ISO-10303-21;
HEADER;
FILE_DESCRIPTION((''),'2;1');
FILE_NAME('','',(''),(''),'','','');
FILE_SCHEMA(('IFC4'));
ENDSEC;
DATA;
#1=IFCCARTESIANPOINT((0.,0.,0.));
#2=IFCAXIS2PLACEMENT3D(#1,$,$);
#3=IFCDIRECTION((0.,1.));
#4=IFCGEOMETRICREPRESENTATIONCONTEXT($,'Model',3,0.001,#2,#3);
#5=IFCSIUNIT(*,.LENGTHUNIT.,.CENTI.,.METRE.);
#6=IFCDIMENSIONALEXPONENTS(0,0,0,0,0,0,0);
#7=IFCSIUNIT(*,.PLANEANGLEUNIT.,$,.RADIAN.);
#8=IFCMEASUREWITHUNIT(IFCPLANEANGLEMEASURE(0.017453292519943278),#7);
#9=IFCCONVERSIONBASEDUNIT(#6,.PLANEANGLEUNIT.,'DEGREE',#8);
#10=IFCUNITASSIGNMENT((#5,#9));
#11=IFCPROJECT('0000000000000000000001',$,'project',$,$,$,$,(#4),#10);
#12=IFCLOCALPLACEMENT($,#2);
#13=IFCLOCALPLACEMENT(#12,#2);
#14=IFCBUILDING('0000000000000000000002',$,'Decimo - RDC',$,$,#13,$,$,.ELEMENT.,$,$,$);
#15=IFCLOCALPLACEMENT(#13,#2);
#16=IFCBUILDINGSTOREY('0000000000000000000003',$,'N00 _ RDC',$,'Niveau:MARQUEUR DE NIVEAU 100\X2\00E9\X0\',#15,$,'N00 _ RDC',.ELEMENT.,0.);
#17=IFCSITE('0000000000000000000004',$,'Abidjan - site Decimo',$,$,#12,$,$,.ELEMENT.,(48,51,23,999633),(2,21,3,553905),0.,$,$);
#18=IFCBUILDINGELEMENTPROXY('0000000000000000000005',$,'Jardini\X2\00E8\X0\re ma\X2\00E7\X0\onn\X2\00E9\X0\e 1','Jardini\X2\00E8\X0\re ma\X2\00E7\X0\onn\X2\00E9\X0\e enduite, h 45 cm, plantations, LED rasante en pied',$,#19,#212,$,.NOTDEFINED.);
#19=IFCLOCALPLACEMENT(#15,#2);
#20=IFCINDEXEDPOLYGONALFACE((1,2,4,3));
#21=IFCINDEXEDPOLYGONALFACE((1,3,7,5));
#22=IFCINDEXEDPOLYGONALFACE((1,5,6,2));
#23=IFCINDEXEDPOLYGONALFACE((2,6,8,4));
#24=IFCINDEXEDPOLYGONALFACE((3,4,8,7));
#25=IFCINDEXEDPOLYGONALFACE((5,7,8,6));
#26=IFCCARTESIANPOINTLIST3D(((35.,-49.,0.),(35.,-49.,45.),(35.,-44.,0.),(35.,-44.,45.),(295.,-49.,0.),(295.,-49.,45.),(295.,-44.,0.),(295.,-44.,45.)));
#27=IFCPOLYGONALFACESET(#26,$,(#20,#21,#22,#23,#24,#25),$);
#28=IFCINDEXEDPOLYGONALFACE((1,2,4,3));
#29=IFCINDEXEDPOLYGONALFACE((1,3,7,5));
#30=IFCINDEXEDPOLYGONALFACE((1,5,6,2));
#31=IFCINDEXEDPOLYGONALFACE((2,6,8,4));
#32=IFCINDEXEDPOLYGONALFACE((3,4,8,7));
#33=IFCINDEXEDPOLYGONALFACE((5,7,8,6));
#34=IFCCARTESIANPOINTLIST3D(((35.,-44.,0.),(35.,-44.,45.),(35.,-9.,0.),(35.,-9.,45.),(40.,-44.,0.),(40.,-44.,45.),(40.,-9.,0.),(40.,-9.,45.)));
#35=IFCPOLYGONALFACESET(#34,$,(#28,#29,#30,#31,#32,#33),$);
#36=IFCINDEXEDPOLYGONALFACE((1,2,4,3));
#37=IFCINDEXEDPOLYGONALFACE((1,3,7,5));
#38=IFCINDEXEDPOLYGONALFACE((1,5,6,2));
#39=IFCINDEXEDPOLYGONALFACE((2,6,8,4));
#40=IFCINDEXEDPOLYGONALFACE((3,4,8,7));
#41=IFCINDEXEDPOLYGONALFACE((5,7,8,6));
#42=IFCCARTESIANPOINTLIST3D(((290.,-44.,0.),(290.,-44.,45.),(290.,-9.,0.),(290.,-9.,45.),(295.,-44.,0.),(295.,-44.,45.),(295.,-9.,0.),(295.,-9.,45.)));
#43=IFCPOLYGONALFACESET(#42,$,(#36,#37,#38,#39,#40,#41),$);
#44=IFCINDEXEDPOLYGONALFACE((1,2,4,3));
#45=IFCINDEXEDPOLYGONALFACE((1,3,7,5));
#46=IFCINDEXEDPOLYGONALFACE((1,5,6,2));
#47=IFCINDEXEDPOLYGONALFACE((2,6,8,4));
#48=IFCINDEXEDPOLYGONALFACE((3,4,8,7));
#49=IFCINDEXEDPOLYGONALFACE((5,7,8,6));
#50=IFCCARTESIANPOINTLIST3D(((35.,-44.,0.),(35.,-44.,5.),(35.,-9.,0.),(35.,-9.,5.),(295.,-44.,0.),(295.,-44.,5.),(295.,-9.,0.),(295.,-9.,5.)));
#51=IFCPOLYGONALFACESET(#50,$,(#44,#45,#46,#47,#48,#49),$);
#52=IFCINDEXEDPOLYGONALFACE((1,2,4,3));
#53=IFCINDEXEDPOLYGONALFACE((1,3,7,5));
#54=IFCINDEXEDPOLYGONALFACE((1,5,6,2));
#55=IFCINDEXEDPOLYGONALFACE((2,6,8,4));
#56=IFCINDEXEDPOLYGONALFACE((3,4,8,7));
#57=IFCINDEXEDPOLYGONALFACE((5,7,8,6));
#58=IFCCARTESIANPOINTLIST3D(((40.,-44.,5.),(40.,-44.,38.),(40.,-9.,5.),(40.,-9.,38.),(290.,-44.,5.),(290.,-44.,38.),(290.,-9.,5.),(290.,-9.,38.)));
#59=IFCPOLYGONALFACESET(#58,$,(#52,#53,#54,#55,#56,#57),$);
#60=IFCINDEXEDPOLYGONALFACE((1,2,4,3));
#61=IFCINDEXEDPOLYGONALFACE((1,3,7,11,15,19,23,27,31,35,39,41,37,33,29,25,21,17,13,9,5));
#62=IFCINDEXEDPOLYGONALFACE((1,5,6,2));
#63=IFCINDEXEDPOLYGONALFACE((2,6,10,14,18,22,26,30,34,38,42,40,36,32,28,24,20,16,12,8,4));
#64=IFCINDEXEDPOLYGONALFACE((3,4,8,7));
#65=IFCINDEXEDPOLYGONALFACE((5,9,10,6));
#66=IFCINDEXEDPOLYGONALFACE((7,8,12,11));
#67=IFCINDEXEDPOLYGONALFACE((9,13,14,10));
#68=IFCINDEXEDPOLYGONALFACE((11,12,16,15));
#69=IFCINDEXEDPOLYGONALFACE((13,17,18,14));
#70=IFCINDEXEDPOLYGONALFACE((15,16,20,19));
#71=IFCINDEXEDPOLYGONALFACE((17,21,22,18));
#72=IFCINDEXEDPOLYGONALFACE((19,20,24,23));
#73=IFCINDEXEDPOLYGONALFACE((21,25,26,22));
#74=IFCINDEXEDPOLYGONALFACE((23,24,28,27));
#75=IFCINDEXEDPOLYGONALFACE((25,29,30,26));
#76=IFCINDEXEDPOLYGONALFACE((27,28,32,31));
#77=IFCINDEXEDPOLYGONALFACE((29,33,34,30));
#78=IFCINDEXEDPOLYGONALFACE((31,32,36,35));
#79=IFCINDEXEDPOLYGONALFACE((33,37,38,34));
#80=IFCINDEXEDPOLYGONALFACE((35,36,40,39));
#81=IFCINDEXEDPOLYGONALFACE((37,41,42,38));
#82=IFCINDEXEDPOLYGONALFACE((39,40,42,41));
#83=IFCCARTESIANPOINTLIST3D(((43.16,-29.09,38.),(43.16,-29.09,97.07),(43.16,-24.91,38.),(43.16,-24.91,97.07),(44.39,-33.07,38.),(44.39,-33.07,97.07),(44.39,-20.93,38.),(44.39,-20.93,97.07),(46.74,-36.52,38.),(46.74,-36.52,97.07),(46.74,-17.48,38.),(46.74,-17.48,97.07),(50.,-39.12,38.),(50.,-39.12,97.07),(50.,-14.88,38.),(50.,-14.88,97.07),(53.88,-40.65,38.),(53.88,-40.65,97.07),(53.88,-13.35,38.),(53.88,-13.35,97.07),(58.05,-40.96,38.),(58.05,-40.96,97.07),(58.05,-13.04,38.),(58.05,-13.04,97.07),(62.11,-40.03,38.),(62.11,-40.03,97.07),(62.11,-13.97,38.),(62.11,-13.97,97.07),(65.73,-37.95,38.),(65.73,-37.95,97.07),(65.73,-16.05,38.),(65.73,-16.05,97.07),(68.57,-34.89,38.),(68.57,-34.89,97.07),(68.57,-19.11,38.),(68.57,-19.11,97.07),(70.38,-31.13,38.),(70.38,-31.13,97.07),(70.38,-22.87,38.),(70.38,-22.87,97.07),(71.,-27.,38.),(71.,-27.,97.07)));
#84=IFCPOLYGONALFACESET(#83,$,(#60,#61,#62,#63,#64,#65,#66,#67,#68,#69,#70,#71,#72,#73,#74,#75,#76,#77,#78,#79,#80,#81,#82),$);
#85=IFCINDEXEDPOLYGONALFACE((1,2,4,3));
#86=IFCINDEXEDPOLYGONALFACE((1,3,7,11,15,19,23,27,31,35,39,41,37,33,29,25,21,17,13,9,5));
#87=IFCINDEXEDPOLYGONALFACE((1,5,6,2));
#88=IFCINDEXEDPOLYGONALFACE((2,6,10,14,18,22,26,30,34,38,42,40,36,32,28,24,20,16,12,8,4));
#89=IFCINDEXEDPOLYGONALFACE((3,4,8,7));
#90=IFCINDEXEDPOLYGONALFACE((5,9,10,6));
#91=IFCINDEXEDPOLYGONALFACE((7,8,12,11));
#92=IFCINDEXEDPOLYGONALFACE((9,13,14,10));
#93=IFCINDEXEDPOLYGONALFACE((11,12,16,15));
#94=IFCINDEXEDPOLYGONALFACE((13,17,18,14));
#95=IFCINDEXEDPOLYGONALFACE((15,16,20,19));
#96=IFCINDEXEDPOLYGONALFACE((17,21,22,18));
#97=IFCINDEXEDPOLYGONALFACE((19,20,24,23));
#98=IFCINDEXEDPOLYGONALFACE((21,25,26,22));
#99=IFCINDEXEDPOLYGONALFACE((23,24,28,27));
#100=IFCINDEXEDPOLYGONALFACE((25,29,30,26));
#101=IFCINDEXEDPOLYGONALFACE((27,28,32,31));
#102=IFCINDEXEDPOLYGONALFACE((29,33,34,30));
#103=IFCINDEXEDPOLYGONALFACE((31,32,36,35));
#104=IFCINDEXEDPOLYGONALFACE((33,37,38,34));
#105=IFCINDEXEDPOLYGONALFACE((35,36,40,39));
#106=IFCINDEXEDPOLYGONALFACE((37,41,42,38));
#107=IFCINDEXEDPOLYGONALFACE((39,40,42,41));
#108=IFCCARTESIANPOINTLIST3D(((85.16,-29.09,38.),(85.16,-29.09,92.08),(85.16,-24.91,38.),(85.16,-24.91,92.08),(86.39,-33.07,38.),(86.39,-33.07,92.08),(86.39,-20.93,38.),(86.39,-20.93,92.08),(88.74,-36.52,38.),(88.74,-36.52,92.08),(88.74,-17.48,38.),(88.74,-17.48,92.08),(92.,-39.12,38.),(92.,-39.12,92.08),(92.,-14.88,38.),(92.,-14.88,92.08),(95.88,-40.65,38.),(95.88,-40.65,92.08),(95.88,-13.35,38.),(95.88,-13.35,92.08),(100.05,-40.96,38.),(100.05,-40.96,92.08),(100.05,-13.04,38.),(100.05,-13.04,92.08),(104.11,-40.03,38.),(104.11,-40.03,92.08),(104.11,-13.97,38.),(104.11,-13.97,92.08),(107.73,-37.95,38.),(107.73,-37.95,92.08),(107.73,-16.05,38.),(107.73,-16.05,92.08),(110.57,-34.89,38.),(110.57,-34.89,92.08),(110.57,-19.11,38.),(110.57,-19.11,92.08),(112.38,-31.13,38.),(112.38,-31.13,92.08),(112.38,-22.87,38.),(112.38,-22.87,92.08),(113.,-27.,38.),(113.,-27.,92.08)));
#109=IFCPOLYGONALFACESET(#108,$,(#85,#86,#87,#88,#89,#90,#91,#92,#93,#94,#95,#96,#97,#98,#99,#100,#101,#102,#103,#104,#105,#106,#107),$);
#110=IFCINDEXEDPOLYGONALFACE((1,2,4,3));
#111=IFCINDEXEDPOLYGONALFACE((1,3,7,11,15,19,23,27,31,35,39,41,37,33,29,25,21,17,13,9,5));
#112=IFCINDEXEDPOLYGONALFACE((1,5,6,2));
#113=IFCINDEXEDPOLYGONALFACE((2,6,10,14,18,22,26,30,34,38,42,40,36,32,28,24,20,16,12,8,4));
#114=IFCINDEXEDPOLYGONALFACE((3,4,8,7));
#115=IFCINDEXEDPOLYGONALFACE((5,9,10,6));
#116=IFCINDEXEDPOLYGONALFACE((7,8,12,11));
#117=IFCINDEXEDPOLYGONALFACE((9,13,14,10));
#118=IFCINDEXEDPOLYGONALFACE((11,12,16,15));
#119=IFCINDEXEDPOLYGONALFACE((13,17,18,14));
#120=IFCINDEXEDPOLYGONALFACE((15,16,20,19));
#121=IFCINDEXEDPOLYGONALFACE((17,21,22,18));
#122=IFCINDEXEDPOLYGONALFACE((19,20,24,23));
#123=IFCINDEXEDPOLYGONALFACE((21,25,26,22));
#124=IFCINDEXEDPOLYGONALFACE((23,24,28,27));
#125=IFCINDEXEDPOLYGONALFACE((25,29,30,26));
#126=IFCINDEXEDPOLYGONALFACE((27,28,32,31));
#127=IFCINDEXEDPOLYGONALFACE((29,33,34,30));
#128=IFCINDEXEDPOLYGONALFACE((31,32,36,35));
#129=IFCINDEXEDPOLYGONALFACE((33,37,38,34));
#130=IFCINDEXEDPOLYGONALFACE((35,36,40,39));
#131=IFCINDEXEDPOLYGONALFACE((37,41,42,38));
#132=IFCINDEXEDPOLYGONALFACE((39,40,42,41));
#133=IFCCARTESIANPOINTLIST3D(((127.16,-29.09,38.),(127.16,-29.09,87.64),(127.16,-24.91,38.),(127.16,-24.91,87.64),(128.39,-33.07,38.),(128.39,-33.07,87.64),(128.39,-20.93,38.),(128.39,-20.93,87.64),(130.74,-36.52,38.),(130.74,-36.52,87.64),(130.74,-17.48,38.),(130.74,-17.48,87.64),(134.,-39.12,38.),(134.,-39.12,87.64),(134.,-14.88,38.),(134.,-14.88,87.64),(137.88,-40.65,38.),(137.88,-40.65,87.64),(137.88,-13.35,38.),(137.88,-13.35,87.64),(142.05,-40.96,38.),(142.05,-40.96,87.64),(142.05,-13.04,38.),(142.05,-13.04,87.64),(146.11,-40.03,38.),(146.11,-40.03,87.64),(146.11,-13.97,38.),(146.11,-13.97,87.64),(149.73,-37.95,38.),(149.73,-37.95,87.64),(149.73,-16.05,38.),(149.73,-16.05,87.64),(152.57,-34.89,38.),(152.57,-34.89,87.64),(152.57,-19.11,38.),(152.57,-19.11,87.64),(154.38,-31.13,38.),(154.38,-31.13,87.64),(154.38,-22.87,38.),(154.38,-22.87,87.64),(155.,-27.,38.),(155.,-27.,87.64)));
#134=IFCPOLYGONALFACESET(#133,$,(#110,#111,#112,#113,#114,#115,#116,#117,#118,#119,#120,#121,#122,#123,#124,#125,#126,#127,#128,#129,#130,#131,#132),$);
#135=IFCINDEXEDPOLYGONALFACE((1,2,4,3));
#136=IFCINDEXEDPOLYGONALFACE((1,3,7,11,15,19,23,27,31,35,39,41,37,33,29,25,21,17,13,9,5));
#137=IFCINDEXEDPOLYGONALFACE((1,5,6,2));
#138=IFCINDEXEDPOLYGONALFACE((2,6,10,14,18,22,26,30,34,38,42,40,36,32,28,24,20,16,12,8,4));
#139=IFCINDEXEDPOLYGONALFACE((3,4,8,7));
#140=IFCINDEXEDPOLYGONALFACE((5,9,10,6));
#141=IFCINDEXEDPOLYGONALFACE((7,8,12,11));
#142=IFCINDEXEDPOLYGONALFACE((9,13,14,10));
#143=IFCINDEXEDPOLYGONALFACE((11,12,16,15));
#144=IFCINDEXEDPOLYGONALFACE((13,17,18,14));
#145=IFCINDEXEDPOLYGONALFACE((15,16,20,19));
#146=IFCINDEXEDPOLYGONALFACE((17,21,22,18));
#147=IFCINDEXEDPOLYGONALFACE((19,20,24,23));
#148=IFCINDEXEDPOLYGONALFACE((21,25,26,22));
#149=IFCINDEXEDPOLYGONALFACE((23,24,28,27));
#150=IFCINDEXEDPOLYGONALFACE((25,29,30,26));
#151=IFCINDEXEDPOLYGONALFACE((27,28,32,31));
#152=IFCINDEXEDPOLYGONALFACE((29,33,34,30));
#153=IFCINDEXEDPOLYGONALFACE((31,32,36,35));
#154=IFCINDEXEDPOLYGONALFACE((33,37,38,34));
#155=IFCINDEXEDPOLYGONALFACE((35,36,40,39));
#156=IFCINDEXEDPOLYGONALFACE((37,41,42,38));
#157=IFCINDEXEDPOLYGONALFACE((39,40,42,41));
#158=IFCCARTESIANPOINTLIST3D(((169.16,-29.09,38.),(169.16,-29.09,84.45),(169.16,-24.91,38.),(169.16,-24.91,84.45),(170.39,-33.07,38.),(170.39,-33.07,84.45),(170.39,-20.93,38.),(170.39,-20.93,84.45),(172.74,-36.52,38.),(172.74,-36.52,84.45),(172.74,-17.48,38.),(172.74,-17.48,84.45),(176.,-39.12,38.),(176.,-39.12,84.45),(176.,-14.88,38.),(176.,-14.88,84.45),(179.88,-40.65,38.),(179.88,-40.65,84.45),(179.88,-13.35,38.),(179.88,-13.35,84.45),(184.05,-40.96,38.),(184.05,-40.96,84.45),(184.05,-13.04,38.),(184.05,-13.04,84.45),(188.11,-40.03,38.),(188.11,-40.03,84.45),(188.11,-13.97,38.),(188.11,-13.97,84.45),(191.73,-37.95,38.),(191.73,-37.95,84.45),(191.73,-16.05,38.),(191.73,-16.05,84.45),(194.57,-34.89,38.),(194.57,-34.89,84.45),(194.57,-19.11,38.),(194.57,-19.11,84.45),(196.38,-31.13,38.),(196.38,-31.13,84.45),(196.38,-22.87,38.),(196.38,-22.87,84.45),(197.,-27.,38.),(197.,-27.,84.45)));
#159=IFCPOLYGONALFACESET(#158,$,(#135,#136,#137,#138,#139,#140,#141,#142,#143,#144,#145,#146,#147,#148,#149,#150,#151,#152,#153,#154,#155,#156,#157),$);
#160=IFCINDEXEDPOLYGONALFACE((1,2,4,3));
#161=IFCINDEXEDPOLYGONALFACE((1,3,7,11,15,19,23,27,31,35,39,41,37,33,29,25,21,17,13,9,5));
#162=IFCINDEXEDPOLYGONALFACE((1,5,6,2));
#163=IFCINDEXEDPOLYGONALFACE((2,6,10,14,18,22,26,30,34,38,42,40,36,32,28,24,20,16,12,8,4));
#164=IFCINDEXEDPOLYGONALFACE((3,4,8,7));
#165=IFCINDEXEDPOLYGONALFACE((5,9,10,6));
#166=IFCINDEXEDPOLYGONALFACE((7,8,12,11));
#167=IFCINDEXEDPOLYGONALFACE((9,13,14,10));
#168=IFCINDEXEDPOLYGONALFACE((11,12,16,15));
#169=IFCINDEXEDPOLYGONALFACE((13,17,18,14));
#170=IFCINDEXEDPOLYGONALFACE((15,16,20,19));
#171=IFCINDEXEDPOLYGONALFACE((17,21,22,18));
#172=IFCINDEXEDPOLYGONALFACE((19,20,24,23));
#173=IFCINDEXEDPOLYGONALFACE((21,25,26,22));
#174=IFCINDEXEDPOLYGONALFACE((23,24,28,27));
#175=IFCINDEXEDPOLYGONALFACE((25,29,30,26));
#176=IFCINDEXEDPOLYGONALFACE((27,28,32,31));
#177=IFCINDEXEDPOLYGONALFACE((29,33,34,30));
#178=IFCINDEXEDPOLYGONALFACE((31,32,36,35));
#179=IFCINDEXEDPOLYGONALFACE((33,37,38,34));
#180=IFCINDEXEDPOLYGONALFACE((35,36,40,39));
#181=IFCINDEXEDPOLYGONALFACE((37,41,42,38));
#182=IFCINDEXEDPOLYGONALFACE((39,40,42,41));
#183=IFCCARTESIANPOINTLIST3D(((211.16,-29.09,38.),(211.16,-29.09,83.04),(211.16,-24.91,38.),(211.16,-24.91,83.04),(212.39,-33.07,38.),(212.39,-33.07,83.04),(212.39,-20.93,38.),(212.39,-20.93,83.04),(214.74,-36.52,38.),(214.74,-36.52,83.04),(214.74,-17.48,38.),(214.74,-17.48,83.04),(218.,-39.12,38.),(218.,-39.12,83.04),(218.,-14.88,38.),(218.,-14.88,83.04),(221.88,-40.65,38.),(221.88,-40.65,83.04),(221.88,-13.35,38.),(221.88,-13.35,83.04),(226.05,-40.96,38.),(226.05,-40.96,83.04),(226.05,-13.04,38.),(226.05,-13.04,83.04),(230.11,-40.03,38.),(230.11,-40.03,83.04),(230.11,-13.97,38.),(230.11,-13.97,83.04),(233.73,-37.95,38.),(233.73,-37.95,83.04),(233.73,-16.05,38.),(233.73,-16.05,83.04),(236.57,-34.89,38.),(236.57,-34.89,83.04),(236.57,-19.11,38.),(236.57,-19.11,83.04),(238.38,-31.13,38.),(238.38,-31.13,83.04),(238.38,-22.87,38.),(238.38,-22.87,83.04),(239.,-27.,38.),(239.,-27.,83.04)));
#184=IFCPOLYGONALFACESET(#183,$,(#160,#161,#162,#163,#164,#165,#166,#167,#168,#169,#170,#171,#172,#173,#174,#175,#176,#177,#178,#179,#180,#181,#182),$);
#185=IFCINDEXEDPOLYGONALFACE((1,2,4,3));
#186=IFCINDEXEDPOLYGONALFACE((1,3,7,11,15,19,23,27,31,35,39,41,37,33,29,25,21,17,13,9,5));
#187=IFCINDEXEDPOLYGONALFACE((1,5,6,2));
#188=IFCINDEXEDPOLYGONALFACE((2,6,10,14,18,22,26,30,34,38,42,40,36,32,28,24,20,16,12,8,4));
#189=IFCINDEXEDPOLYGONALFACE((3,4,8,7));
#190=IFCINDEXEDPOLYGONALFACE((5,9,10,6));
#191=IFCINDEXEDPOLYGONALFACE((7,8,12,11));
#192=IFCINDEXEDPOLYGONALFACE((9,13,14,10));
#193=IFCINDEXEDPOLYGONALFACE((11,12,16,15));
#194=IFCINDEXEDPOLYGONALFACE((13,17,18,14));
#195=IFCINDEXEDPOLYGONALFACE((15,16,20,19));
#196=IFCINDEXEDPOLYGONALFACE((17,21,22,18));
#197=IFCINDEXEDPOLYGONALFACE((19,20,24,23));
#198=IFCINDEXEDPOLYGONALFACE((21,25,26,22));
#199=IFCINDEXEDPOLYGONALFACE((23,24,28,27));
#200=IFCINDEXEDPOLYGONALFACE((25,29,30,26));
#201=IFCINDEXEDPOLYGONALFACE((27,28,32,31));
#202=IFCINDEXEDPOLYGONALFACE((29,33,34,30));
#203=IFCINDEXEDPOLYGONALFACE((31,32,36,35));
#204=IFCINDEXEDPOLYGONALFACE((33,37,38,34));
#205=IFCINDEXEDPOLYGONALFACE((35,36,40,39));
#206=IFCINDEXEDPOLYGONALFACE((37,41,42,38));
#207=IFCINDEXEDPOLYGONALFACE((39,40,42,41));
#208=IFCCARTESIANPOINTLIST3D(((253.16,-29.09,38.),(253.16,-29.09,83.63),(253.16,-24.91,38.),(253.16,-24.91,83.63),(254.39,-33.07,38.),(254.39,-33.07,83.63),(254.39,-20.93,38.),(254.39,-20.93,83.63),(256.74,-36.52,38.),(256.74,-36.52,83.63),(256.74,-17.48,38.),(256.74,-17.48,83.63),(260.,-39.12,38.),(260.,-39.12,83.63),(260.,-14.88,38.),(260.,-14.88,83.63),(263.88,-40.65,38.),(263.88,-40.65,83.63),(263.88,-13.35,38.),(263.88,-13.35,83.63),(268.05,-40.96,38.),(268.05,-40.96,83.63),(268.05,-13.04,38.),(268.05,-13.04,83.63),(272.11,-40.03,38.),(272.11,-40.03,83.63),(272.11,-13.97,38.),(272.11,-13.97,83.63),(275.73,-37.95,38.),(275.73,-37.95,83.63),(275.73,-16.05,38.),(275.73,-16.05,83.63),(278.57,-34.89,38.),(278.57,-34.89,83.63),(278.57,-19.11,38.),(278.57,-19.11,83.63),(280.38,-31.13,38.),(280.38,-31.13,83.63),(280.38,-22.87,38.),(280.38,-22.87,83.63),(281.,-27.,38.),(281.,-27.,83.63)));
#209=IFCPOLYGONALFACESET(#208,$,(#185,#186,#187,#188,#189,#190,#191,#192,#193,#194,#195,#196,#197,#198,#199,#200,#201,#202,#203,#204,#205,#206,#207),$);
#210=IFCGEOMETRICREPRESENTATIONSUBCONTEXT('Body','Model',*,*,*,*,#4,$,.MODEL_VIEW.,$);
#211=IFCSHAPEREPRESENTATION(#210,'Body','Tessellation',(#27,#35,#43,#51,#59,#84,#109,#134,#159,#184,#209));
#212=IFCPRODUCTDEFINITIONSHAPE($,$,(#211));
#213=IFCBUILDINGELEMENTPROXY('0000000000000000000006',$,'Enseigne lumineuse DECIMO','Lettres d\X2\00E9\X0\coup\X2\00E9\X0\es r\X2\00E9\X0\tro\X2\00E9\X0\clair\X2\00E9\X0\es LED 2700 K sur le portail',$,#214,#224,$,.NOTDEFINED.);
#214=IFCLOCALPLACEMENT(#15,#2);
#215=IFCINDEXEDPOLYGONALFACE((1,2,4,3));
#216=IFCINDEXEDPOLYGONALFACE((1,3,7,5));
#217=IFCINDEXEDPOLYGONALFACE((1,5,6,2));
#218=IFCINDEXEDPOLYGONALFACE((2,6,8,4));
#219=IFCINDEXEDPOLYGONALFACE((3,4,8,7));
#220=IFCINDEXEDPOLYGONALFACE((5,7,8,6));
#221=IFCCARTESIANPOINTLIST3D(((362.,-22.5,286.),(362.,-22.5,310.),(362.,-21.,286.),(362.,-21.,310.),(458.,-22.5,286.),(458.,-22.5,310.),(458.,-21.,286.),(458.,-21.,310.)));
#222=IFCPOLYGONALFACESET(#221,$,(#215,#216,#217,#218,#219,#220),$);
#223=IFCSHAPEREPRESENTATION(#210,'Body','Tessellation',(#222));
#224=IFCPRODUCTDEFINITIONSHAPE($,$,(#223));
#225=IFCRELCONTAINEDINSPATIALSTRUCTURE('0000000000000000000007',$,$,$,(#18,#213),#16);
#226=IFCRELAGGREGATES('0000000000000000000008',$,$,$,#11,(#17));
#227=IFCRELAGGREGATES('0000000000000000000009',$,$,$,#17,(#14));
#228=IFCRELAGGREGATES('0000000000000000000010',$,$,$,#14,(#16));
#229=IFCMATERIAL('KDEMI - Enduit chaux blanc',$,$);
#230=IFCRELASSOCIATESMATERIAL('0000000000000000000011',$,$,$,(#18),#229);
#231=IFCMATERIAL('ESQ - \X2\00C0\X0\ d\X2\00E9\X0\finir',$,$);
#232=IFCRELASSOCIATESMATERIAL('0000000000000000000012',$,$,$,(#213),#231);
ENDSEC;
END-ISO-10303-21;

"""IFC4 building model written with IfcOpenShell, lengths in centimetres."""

from ifc_helpers import new_model, entity, si_unit, converted_unit, direction, frame, frame_2d, origin, origin_with_axes, place, context, subcontext, project, spatial, rectangle, circle, extrude, material, element, save


model = new_model("IFC4")

# Units and contexts
model_context = context("Model", 3, precision=0.001, world=origin(), true_north=direction((0.0, 1.0)))
body_context = subcontext(model_context, "Body", "Model", "MODEL_VIEW")
ifc_project = project(units=[si_unit("LENGTHUNIT", "METRE", prefix="CENTI"), converted_unit("PLANEANGLEUNIT", "DEGREE", entity("IfcPlaneAngleMeasure", 0.017453292519943278), si_unit("PLANEANGLEUNIT", "RADIAN"), dimensions=[0, 0, 0, 0, 0, 0, 0])], contexts=[model_context])

# Site, building, storey
site_placement = place(None, origin())
site = spatial("IfcSite", under=ifc_project, at=site_placement, Name="Abidjan - site Decimo", CompositionType="ELEMENT", RefLatitude=(48, 51, 23, 999633), RefLongitude=(2, 21, 3, 553905), RefElevation=0.0)
building_placement = place(site_placement, origin())
building = spatial("IfcBuilding", under=site, at=building_placement, Name="Decimo - RDC", CompositionType="ELEMENT")
storey_placement = place(building_placement, origin())
storey = spatial("IfcBuildingStorey", under=building, at=storey_placement, Name="N00 _ RDC", ObjectType="Niveau:MARQUEUR DE NIVEAU 100é", LongName="N00 _ RDC", CompositionType="ELEMENT", Elevation=0.0)

# Building element proxies
ifc_material_1 = material(Name="KDEMI - Enduit chaux blanc")
proxy_1_placement = place(storey_placement, origin_with_axes())
element("IfcBuildingElementProxy", 1, at=proxy_1_placement, inside=storey, material=ifc_material_1, Name="Jardinière maçonnée 1", Description="Jardinière maçonnée enduite, h 45 cm, plantations, LED rasante en pied", PredefinedType="NOTDEFINED", context=body_context, shape_type="SweptSolid", body=[
    extrude(rectangle(XDim=260.0, YDim=5.0, at=frame_2d((165.0, -46.5))), origin(), (0.0, 0.0, 1.0), 45.0),
    extrude(rectangle(XDim=5.0, YDim=35.0, at=frame_2d((37.5, -26.5))), origin(), (0.0, 0.0, 1.0), 45.0),
    extrude(rectangle(XDim=5.0, YDim=35.0, at=frame_2d((292.5, -26.5))), origin(), (0.0, 0.0, 1.0), 45.0),
    extrude(rectangle(XDim=260.0, YDim=35.0, at=frame_2d((165.0, -26.5))), origin(), (0.0, 0.0, 1.0), 5.0),
    extrude(rectangle(XDim=250.0, YDim=35.0, at=frame_2d((165.0, -26.5))), frame((0.0, 0.0, 5.0)), (0.0, 0.0, 1.0), 33.0),
    extrude(circle(Radius=14.0, at=frame_2d((57.0, -27.0))), frame((0.0, 0.0, 38.0)), (0.0, 0.0, 1.0), 59.07),
    extrude(circle(Radius=14.0, at=frame_2d((99.0, -27.0))), frame((0.0, 0.0, 38.0)), (0.0, 0.0, 1.0), 54.08),
    extrude(circle(Radius=14.0, at=frame_2d((141.0, -27.0))), frame((0.0, 0.0, 38.0)), (0.0, 0.0, 1.0), 49.64),
    extrude(circle(Radius=14.0, at=frame_2d((183.0, -27.0))), frame((0.0, 0.0, 38.0)), (0.0, 0.0, 1.0), 46.45),
    extrude(circle(Radius=14.0, at=frame_2d((225.0, -27.0))), frame((0.0, 0.0, 38.0)), (0.0, 0.0, 1.0), 45.04),
    extrude(circle(Radius=14.0, at=frame_2d((267.0, -27.0))), frame((0.0, 0.0, 38.0)), (0.0, 0.0, 1.0), 45.63),
])
ifc_material_2 = material(Name="ESQ - À définir")
proxy_2_placement = place(storey_placement, origin_with_axes())
element("IfcBuildingElementProxy", 2, at=proxy_2_placement, inside=storey, material=ifc_material_2, Name="Enseigne lumineuse DECIMO", Description="Lettres découpées rétroéclairées LED 2700 K sur le portail", PredefinedType="NOTDEFINED", context=body_context, shape_type="SweptSolid", body=[
    extrude(rectangle(XDim=96.0, YDim=1.5, at=frame_2d((410.0, -21.75))), frame((0.0, 0.0, 286.0)), (0.0, 0.0, 1.0), 24.0),
])

save(model, "model.ifc")
